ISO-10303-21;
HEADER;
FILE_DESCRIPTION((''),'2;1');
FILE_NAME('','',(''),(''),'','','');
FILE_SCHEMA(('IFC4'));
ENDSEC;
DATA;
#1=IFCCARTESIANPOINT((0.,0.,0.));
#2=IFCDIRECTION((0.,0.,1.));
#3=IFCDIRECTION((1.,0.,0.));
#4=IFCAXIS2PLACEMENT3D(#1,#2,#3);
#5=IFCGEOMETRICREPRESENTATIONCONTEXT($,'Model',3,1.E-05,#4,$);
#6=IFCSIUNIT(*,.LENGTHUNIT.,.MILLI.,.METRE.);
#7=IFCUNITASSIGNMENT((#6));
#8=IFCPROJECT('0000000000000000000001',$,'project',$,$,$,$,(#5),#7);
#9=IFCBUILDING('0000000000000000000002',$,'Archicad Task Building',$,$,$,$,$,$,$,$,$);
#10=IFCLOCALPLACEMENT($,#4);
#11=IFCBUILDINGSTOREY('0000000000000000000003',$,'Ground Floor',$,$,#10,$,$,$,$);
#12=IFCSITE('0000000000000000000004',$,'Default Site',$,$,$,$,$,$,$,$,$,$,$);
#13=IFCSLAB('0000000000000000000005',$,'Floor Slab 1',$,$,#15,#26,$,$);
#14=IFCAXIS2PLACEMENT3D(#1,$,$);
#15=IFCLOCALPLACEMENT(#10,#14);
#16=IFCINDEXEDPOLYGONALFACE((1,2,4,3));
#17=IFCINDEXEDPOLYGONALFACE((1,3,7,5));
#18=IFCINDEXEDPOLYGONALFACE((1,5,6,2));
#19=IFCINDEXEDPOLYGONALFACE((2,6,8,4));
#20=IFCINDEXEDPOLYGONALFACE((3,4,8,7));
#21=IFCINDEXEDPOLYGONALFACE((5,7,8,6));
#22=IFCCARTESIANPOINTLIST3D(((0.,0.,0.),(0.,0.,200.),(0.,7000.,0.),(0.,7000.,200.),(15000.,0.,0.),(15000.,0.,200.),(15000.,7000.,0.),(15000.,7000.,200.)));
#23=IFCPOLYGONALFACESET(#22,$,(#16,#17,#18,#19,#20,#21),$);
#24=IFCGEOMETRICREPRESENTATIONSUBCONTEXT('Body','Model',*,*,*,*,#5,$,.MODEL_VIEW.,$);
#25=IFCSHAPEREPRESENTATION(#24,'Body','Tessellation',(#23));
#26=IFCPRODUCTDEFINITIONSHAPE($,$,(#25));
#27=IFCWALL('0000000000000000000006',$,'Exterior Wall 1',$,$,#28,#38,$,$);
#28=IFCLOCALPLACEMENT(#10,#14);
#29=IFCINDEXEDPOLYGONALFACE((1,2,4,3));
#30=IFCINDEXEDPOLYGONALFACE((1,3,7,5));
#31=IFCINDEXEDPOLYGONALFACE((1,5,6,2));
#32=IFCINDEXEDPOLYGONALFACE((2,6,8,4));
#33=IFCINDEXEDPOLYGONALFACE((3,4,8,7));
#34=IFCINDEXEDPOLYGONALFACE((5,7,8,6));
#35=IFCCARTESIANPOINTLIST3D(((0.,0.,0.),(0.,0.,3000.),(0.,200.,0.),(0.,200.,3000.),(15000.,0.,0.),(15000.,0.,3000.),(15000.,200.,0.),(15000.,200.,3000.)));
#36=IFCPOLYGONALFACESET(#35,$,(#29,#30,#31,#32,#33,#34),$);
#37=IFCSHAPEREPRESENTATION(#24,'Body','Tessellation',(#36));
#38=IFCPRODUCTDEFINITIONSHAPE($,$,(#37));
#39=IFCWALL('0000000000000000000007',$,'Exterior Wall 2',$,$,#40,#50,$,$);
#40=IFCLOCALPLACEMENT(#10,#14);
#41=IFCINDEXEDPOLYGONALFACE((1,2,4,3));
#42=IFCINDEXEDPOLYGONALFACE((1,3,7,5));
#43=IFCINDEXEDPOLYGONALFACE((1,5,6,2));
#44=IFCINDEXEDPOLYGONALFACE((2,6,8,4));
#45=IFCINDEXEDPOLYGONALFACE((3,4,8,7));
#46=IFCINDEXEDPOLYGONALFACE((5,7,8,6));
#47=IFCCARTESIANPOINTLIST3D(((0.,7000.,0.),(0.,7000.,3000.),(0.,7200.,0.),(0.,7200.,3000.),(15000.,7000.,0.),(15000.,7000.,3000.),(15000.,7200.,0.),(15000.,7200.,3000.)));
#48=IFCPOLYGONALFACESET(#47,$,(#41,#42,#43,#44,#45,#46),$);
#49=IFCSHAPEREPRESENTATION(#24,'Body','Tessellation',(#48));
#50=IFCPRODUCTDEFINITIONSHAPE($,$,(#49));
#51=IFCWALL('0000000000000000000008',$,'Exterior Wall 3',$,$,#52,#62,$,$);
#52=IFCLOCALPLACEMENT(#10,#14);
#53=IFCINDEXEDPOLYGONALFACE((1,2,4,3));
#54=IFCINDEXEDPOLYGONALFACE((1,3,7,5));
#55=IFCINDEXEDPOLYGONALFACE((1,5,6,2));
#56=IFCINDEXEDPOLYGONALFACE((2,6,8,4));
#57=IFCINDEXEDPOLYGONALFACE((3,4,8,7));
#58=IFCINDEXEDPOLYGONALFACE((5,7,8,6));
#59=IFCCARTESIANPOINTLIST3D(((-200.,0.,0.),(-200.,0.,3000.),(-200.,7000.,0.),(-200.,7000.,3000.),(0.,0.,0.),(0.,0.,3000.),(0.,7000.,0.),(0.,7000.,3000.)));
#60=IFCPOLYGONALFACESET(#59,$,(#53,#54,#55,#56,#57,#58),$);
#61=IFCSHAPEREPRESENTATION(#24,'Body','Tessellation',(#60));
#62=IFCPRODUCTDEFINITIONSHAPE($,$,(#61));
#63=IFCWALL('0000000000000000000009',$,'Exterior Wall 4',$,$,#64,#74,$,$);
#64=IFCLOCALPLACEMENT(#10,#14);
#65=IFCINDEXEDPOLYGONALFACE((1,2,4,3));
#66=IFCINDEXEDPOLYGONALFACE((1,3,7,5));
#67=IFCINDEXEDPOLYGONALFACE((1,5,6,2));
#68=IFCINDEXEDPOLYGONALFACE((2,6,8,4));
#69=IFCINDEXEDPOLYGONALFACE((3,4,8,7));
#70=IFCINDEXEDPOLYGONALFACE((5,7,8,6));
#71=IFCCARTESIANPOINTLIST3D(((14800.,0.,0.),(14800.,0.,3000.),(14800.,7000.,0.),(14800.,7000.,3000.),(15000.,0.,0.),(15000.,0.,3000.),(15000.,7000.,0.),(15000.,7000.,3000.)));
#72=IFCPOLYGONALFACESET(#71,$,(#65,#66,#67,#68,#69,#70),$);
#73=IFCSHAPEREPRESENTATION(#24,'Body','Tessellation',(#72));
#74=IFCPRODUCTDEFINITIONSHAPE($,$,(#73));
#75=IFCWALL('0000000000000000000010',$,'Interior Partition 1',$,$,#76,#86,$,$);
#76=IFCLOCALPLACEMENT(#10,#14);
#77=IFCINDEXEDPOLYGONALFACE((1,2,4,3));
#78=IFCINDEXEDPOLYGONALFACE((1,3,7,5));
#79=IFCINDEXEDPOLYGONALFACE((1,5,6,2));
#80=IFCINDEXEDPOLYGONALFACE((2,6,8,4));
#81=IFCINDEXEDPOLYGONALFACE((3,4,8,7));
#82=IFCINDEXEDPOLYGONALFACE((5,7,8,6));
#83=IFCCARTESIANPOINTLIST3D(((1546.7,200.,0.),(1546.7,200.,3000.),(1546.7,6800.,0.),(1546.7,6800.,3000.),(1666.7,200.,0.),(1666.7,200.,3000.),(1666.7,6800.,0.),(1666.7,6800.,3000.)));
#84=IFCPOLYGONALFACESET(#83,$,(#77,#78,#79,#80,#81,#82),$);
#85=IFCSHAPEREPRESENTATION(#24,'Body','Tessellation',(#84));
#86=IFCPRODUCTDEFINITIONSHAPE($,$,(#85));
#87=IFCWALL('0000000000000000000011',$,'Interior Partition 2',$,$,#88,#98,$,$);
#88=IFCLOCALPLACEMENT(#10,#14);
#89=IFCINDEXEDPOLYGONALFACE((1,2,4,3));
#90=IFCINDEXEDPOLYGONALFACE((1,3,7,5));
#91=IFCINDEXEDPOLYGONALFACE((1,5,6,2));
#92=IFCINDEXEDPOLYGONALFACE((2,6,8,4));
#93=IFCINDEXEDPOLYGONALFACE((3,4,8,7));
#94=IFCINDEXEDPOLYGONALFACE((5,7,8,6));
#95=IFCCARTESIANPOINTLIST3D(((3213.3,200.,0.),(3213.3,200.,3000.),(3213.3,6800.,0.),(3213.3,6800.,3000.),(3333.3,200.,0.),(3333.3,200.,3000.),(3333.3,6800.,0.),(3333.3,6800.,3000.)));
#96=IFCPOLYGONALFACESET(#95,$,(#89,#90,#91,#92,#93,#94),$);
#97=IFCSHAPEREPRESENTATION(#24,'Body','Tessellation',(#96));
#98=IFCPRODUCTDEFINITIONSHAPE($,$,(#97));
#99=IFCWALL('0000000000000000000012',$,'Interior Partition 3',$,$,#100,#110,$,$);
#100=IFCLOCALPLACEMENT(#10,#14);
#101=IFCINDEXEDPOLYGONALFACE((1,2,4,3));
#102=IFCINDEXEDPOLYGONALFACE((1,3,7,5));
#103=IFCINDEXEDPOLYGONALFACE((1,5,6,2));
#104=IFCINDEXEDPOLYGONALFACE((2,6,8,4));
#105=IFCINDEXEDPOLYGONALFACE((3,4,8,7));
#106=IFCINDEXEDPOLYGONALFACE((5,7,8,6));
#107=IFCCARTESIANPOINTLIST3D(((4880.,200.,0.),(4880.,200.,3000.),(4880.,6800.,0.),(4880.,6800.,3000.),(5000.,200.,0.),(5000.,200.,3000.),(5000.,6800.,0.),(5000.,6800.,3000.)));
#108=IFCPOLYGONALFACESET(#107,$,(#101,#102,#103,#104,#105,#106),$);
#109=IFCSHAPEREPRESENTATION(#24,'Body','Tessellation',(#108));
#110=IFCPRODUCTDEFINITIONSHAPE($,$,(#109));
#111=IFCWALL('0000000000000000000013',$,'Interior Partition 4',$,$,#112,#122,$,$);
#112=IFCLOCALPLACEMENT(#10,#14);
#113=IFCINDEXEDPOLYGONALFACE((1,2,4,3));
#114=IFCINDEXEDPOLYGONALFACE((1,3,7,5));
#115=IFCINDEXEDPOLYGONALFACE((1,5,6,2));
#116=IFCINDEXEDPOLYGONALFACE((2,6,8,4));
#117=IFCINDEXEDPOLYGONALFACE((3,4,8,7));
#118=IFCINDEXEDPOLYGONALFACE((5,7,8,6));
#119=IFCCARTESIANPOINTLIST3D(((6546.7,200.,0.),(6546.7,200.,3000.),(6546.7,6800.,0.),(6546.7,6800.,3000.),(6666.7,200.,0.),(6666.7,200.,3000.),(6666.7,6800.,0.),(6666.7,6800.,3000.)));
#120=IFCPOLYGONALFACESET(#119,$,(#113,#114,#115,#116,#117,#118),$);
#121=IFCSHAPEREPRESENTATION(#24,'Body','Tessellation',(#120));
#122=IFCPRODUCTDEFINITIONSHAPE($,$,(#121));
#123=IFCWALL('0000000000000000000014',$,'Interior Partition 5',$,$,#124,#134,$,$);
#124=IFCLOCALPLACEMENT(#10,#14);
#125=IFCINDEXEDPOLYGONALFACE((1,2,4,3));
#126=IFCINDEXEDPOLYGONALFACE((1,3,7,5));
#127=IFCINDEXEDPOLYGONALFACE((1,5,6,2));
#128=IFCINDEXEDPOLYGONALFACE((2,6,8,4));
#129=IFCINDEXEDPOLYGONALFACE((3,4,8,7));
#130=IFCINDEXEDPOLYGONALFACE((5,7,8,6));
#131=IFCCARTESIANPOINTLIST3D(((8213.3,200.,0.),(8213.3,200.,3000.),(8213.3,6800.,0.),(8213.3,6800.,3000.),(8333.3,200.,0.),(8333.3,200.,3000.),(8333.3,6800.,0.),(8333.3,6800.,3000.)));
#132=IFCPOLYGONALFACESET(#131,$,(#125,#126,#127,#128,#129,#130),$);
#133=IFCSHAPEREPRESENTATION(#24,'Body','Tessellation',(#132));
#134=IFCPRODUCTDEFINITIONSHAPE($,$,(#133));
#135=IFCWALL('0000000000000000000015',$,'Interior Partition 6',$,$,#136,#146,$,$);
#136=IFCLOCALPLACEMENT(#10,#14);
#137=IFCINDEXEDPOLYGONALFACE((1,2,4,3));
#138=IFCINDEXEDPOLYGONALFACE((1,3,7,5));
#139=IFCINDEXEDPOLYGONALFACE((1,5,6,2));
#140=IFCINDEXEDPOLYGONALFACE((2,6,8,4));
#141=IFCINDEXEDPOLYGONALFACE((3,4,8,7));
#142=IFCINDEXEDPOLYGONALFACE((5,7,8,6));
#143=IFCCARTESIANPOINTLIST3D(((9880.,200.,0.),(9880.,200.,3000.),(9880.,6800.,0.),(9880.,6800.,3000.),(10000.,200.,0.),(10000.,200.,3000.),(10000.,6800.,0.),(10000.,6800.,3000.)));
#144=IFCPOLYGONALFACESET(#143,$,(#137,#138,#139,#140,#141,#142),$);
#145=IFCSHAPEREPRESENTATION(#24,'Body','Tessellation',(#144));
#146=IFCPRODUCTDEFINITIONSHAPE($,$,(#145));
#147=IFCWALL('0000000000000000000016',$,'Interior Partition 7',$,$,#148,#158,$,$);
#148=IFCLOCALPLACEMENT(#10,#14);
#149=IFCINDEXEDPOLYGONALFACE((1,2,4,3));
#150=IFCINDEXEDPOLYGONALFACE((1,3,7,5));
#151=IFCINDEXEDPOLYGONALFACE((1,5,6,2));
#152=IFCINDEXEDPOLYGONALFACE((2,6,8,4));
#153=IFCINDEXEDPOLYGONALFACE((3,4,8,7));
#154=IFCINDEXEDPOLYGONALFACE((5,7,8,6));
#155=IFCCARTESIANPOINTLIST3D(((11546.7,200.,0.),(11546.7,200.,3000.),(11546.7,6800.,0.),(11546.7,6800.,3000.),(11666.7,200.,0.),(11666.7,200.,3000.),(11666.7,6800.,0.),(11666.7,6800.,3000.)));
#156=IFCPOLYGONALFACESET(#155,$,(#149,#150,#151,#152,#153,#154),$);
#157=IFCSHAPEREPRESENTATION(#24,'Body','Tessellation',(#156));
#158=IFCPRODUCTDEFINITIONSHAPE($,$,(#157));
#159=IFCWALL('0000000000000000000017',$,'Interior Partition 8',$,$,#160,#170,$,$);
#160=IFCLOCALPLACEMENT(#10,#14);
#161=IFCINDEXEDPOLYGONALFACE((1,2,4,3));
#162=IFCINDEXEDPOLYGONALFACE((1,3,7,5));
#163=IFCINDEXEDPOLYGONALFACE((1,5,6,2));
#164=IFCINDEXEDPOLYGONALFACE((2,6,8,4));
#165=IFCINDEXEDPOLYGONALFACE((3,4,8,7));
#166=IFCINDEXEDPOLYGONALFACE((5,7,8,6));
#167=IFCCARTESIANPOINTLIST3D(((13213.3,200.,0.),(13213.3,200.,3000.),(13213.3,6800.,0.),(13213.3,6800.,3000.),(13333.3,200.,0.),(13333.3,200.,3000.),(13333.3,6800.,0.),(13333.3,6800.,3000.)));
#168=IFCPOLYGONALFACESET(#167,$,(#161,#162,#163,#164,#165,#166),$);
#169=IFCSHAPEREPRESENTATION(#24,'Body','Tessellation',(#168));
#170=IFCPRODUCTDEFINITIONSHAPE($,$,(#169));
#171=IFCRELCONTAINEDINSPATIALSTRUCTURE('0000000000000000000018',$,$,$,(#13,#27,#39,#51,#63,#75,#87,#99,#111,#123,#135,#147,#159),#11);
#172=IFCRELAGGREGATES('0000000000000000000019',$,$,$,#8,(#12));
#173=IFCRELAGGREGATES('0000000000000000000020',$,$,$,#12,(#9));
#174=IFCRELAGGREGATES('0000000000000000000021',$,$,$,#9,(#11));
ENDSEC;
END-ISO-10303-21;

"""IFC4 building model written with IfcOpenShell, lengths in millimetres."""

from ifc_helpers import new_model, si_unit, frame, origin_with_axes, place, context, subcontext, project, spatial, indexed_curve, outline, extrude, element, save


model = new_model("IFC4")

# Units and contexts
model_context = context("Model", 3, precision=1e-05, world=origin_with_axes())
body_context = subcontext(model_context, "Body", "Model", "MODEL_VIEW")
ifc_project = project(units=[si_unit("LENGTHUNIT", "METRE", prefix="MILLI")], contexts=[model_context])

# Site, building, storey
site = spatial("IfcSite", under=ifc_project, Name="Default Site")
building = spatial("IfcBuilding", under=site, Name="Archicad Task Building")
storey_placement = place(None, origin_with_axes())
storey = spatial("IfcBuildingStorey", under=building, at=storey_placement, Name="Ground Floor")

# Slab
slab_placement = place(storey_placement, origin_with_axes())
element("IfcSlab", 1, at=slab_placement, inside=storey, Name="Floor Slab 1", context=body_context, shape_type="SweptSolid", body=[
    extrude(outline(indexed_curve([(0.0, 0.0), (15000.0, 0.0), (15000.0, 7000.0), (0.0, 7000.0), (0.0, 0.0)])), None, (0.0, 0.0, 1.0), 200.0),
])

# Walls
for number, where, z_axis, x_axis, name in (
    (2, (0.0, 0.0, 0.0), (0.0, 0.0, 1.0), (1.0, 0.0, 0.0), "Exterior Wall 1"),
    (3, (0.0, 7000.0, 0.0), (0.0, 0.0, 1.0), (1.0, 0.0, 0.0), "Exterior Wall 2"),
):
    element("IfcWall", number, at=place(storey_placement, frame(where, z_axis=z_axis, x_axis=x_axis)), inside=storey, Name=name, context=body_context, shape_type="SweptSolid", body=[
        extrude(outline(indexed_curve([(0.0, 0.0), (0.0, 200.0), (15000.0, 200.0), (15000.0, 0.0), (0.0, 0.0)], self_intersect=False)), origin_with_axes(), (0.0, 0.0, 1.0), 3000.0),
    ])
for number, where, z_axis, x_axis, name in (
    (4, (0.0, 0.0, 0.0), (0.0, 0.0, 1.0), (0.0, 1.0, 0.0), "Exterior Wall 3"),
    (5, (15000.0, 0.0, 0.0), (0.0, 0.0, 1.0), (0.0, 1.0, 0.0), "Exterior Wall 4"),
):
    element("IfcWall", number, at=place(storey_placement, frame(where, z_axis=z_axis, x_axis=x_axis)), inside=storey, Name=name, context=body_context, shape_type="SweptSolid", body=[
        extrude(outline(indexed_curve([(0.0, 0.0), (0.0, 200.0), (7000.0, 200.0), (7000.0, 0.0), (0.0, 0.0)], self_intersect=False)), origin_with_axes(), (0.0, 0.0, 1.0), 3000.0),
    ])
for number, where, z_axis, x_axis, name in (
    (6, (1666.7, 200.0, 0.0), (0.0, 0.0, 1.0), (0.0, 1.0, 0.0), "Interior Partition 1"),
    (7, (3333.3, 200.0, 0.0), (0.0, 0.0, 1.0), (0.0, 1.0, 0.0), "Interior Partition 2"),
    (8, (5000.0, 200.0, 0.0), (0.0, 0.0, 1.0), (0.0, 1.0, 0.0), "Interior Partition 3"),
    (9, (6666.7, 200.0, 0.0), (0.0, 0.0, 1.0), (0.0, 1.0, 0.0), "Interior Partition 4"),
    (10, (8333.3, 200.0, 0.0), (0.0, 0.0, 1.0), (0.0, 1.0, 0.0), "Interior Partition 5"),
    (11, (10000.0, 200.0, 0.0), (0.0, 0.0, 1.0), (0.0, 1.0, 0.0), "Interior Partition 6"),
    (12, (11666.7, 200.0, 0.0), (0.0, 0.0, 1.0), (0.0, 1.0, 0.0), "Interior Partition 7"),
    (13, (13333.3, 200.0, 0.0), (0.0, 0.0, 1.0), (0.0, 1.0, 0.0), "Interior Partition 8"),
):
    element("IfcWall", number, at=place(storey_placement, frame(where, z_axis=z_axis, x_axis=x_axis)), inside=storey, Name=name, context=body_context, shape_type="SweptSolid", body=[
        extrude(outline(indexed_curve([(0.0, 0.0), (0.0, 120.0), (6600.0, 120.0), (6600.0, 0.0), (0.0, 0.0)], self_intersect=False)), origin_with_axes(), (0.0, 0.0, 1.0), 3000.0),
    ])

save(model, "model.ifc")
